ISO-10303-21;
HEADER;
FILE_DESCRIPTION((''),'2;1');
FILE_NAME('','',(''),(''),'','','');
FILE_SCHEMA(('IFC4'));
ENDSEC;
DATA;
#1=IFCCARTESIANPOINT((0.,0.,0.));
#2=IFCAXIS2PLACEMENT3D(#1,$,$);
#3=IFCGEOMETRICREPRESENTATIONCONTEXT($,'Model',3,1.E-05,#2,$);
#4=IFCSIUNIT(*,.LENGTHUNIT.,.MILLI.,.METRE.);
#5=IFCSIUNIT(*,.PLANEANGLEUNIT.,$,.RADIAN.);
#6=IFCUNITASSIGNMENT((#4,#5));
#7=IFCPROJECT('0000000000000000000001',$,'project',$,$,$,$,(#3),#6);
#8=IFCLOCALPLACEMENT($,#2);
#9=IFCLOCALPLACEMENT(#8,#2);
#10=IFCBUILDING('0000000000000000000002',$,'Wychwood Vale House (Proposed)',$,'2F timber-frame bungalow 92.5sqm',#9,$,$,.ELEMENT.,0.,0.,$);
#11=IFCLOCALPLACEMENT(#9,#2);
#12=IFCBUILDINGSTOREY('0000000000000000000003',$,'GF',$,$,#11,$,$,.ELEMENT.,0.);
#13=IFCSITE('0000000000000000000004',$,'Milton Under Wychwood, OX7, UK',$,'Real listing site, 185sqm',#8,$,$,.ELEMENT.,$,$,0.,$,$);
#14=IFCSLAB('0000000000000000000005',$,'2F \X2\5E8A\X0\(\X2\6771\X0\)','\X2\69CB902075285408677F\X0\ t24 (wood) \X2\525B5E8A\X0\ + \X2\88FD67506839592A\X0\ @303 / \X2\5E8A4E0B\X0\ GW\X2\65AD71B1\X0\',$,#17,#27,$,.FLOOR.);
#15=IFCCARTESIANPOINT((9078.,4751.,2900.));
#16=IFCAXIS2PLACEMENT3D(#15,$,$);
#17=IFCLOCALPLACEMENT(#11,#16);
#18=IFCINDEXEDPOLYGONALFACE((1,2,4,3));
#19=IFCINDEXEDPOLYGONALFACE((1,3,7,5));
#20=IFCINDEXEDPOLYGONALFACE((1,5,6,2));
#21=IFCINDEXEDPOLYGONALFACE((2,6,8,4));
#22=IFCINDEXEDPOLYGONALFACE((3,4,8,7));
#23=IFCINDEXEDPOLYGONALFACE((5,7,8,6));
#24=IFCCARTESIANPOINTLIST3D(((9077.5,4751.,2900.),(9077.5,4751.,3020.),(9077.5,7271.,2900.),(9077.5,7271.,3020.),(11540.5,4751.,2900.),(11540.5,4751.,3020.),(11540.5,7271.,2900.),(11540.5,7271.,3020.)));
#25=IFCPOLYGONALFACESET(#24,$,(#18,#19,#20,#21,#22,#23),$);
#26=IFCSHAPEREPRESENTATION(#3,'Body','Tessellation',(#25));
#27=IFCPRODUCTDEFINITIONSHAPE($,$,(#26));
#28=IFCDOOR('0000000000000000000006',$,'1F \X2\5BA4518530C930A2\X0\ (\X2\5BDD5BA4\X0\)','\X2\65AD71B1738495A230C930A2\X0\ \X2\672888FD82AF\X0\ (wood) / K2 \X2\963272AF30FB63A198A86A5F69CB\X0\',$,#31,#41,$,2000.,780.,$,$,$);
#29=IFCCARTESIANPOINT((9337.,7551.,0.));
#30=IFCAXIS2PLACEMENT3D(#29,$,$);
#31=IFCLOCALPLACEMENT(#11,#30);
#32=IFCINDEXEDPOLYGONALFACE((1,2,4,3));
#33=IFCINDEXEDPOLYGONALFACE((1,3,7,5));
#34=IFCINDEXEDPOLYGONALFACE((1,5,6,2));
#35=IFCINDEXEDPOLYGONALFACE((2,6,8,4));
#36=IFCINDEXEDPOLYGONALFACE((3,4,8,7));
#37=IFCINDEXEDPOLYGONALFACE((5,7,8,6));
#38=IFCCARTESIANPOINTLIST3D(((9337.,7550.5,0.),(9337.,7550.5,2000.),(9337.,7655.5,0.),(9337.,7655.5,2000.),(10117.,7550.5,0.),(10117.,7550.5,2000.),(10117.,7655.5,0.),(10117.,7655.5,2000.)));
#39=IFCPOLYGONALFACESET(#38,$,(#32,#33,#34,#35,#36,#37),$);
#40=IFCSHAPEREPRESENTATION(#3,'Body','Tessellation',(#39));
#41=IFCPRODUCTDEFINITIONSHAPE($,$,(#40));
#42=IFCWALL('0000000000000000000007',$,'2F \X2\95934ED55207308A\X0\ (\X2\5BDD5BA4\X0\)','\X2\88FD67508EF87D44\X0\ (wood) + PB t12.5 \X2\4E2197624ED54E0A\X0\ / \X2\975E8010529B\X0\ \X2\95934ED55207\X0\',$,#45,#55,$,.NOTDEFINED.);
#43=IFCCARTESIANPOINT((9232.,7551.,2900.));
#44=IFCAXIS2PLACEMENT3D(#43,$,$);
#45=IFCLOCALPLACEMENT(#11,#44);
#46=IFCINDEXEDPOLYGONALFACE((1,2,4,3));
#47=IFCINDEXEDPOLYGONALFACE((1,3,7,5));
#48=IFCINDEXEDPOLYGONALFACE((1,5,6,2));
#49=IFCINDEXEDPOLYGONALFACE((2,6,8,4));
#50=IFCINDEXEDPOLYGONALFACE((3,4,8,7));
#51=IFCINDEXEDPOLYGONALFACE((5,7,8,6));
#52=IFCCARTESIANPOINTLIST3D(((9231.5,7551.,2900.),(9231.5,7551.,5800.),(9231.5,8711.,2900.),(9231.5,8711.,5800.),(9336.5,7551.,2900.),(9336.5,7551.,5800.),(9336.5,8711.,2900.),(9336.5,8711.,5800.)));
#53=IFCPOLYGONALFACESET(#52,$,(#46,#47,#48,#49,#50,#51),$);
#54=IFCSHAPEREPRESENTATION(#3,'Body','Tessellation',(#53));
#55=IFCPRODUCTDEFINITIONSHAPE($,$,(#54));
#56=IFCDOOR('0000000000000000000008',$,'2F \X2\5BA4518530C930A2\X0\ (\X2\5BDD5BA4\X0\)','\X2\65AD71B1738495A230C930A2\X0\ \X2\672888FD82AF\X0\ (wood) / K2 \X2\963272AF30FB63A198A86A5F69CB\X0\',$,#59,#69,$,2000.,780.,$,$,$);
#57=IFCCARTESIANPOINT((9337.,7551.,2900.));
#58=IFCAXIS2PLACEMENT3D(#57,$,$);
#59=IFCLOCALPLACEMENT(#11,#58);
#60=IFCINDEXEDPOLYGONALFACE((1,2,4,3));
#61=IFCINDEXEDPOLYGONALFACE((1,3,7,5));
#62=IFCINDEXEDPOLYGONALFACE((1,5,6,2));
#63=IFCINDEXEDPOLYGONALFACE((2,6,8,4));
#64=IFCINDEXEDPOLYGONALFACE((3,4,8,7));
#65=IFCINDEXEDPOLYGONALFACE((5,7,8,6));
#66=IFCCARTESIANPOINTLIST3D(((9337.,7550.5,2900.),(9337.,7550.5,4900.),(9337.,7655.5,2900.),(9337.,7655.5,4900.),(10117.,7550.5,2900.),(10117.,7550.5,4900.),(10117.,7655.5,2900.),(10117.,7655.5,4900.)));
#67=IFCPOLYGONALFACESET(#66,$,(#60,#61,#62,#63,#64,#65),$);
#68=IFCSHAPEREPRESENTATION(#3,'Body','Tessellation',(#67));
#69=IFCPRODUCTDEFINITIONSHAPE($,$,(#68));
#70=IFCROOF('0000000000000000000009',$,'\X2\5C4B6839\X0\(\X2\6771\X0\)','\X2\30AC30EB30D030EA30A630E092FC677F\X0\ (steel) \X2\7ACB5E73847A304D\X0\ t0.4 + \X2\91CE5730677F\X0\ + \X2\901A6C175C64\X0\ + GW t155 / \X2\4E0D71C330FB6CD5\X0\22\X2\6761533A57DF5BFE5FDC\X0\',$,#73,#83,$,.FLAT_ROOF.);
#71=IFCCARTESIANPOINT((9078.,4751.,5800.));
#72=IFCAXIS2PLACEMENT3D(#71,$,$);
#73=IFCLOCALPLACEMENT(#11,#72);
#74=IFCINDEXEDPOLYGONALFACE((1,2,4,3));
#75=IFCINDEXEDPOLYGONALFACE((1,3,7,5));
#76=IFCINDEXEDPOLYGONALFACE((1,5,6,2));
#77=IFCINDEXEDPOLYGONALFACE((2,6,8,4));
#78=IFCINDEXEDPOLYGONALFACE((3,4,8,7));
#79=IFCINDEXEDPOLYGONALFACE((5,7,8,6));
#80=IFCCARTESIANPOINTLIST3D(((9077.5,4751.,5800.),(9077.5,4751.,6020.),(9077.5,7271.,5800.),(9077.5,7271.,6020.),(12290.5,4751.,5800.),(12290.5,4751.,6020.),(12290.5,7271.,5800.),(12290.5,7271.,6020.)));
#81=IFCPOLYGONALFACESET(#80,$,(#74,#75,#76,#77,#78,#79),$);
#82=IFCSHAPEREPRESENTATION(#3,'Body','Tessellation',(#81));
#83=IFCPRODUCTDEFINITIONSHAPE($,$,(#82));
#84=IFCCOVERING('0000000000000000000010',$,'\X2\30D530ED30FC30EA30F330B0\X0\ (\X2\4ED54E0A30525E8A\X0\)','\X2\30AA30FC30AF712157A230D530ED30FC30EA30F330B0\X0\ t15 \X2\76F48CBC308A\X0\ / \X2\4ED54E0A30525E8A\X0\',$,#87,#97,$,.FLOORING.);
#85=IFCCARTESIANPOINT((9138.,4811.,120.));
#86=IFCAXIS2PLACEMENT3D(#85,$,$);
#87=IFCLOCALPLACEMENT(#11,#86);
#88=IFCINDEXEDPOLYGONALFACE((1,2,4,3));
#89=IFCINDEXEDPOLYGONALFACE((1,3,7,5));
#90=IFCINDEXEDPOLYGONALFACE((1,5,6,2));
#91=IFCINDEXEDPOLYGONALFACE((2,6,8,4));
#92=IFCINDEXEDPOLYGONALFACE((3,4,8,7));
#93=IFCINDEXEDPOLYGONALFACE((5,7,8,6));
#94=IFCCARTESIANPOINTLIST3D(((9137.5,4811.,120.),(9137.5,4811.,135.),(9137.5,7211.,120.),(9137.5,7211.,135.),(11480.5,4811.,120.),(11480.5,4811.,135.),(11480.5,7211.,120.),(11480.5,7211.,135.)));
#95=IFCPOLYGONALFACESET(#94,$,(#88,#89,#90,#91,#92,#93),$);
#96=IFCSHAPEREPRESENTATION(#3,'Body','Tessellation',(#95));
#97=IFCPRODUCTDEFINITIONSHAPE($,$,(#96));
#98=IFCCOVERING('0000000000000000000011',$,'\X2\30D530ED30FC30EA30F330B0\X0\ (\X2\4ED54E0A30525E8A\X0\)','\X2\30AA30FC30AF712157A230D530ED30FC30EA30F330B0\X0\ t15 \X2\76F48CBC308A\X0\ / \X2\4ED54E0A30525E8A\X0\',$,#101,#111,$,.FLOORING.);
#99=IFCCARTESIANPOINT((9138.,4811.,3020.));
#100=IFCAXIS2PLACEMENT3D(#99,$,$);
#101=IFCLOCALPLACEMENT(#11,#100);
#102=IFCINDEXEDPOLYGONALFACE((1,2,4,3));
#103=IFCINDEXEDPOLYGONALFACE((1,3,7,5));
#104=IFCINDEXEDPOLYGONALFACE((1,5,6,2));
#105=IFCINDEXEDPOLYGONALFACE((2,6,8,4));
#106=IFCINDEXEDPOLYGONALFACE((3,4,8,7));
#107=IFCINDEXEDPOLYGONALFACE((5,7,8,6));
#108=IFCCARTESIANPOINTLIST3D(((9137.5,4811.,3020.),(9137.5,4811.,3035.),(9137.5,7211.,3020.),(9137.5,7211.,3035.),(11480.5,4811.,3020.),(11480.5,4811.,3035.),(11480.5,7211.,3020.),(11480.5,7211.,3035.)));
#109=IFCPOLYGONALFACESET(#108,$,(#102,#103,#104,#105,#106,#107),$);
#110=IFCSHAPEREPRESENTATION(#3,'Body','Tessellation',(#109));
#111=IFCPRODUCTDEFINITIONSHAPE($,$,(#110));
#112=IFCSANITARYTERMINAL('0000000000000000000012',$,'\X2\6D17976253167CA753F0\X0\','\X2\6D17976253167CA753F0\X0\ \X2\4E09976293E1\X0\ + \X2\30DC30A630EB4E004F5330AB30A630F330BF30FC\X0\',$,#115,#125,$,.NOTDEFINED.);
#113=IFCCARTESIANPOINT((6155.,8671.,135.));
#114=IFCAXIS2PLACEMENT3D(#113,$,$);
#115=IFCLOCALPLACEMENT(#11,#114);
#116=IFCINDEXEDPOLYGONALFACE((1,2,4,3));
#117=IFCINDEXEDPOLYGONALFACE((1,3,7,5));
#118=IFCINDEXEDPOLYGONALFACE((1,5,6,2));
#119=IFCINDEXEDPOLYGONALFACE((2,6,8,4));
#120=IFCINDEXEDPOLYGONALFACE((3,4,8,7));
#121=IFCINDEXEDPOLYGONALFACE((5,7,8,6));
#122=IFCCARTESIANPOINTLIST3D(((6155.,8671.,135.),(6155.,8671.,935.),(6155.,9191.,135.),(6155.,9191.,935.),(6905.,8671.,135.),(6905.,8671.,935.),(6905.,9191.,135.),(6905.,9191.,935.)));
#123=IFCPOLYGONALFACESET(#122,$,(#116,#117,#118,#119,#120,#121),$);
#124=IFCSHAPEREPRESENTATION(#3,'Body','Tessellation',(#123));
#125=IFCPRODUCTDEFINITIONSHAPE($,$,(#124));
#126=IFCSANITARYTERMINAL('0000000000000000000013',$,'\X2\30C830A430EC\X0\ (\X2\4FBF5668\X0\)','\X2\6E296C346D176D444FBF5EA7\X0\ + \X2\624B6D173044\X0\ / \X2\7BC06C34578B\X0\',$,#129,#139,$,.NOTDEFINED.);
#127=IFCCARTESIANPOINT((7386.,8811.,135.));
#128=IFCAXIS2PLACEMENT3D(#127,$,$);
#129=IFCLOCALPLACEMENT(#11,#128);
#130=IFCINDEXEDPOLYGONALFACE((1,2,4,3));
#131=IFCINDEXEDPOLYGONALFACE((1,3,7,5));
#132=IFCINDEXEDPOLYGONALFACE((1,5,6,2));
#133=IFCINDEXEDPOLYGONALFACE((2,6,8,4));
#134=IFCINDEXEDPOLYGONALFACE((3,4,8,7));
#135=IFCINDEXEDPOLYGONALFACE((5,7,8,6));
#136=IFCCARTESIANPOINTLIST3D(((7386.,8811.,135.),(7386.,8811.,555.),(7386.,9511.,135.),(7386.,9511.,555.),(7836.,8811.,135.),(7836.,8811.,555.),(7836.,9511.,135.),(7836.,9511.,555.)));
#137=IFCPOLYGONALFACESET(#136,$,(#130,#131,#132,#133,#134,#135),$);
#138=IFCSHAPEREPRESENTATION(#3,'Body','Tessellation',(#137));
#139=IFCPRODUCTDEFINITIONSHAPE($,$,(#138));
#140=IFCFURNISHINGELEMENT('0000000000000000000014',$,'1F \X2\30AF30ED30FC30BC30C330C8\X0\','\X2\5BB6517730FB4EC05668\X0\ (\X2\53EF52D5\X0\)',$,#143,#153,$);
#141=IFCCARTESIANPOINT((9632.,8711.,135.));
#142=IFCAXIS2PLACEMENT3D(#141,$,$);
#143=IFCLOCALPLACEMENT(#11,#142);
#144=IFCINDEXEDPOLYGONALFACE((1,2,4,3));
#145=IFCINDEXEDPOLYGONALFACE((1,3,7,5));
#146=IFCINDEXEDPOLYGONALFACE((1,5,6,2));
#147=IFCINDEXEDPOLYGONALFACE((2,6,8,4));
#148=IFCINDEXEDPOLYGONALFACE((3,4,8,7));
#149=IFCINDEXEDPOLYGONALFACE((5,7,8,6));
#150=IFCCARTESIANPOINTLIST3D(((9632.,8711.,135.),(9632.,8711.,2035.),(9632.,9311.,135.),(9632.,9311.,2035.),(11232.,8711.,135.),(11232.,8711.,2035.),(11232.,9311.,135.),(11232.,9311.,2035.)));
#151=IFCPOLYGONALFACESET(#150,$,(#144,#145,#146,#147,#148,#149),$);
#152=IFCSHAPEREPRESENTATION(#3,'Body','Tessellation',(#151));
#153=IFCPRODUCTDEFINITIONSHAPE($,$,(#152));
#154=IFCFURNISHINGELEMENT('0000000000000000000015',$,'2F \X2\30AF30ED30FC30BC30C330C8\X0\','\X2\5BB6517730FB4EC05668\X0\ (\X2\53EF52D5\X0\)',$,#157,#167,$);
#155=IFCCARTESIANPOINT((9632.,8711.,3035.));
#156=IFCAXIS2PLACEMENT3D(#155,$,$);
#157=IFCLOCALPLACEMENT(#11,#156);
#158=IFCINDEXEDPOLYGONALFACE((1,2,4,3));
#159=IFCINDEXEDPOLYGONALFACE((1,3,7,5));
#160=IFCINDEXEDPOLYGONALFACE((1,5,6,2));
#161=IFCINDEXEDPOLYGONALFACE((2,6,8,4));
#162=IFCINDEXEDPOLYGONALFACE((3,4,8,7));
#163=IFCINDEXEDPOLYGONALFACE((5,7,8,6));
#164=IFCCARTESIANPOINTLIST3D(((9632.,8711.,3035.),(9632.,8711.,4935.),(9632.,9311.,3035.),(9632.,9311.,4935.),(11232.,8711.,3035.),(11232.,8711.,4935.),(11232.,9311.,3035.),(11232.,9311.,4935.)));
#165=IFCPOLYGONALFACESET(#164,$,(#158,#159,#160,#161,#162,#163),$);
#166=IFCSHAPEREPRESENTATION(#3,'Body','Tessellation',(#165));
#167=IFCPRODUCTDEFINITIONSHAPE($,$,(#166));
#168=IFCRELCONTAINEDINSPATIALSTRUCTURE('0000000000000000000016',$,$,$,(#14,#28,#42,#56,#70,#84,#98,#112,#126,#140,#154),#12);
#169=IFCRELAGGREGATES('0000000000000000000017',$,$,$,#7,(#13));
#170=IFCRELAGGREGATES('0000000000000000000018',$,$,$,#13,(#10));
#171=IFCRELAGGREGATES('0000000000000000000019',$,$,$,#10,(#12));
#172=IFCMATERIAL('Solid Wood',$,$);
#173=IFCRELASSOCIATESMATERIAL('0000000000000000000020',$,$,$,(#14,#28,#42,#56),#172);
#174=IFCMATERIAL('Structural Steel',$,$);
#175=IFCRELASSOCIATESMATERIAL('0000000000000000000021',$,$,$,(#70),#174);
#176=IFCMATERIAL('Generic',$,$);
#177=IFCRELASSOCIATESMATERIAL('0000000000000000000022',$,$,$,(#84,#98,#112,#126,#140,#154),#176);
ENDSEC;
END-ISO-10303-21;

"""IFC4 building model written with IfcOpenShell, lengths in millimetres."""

from ifc_helpers import new_model, si_unit, frame, frame_2d, origin, place, context, project, spatial, rectangle, extrude, material, element, save


model = new_model("IFC4")

# Units and contexts
model_context = context("Model", 3, precision=1e-05, world=origin())
ifc_project = project(units=[si_unit("LENGTHUNIT", "METRE", prefix="MILLI"), si_unit("PLANEANGLEUNIT", "RADIAN")], contexts=[model_context])

# Site, building, storey
site_placement = place(None, origin())
site = spatial("IfcSite", under=ifc_project, at=site_placement, Name="Milton Under Wychwood, OX7, UK", ObjectType="Real listing site, 185sqm", CompositionType="ELEMENT", RefElevation=0.0)
building_placement = place(site_placement, origin())
building = spatial("IfcBuilding", under=site, at=building_placement, Name="Wychwood Vale House (Proposed)", ObjectType="2F timber-frame bungalow 92.5sqm", CompositionType="ELEMENT", ElevationOfRefHeight=0.0, ElevationOfTerrain=0.0)
storey_placement = place(building_placement, origin())
storey = spatial("IfcBuildingStorey", under=building, at=storey_placement, Name="GF", CompositionType="ELEMENT", Elevation=0.0)

# Slab
ifc_material_1 = material(Name="Solid Wood")
slab_1_placement = place(storey_placement, frame((9078.0, 4751.0, 2900.0)))
element("IfcSlab", 1, at=slab_1_placement, inside=storey, material=ifc_material_1, Name="2F 床(東)", Description="構造用合板 t24 (wood) 剛床 + 製材根太 @303 / 床下 GW断熱", PredefinedType="FLOOR", context=model_context, shape_type="SweptSolid", body=[
    extrude(rectangle(XDim=2463.0, YDim=2520.0, at=frame_2d((1231.0, 1260.0))), frame((9078.0, 4751.0, 2900.0)), (0.0, 0.0, 1.0), 120.0),
])

# Door
door_1_placement = place(storey_placement, frame((9337.0, 7551.0, 0.0)))
element("IfcDoor", 2, at=door_1_placement, inside=storey, material=ifc_material_1, Name="1F 室内ドア (寝室)", Description="断熱玄関ドア 木製芯 (wood) / K2 防犯・採風機構", OverallHeight=2000.0, OverallWidth=780.0, context=model_context, shape_type="SweptSolid", body=[
    extrude(rectangle(XDim=780.0, YDim=105.0, at=frame_2d((390.0, 52.0))), frame((9337.0, 7551.0, 0.0)), (0.0, 0.0, 1.0), 2000.0),
])

# Wall
wall_1_placement = place(storey_placement, frame((9232.0, 7551.0, 2900.0)))
element("IfcWall", 3, at=wall_1_placement, inside=storey, material=ifc_material_1, Name="2F 間仕切り (寝室)", Description="製材軸組 (wood) + PB t12.5 両面仕上 / 非耐力 間仕切", PredefinedType="NOTDEFINED", context=model_context, shape_type="SweptSolid", body=[
    extrude(rectangle(XDim=105.0, YDim=1160.0, at=frame_2d((52.0, 580.0))), frame((9232.0, 7551.0, 2900.0)), (0.0, 0.0, 1.0), 2900.0),
])

# Door
door_2_placement = place(storey_placement, frame((9337.0, 7551.0, 2900.0)))
element("IfcDoor", 4, at=door_2_placement, inside=storey, material=ifc_material_1, Name="2F 室内ドア (寝室)", Description="断熱玄関ドア 木製芯 (wood) / K2 防犯・採風機構", OverallHeight=2000.0, OverallWidth=780.0, context=model_context, shape_type="SweptSolid", body=[
    extrude(rectangle(XDim=780.0, YDim=105.0, at=frame_2d((390.0, 52.0))), frame((9337.0, 7551.0, 2900.0)), (0.0, 0.0, 1.0), 2000.0),
])

# Roof
ifc_material_2 = material(Name="Structural Steel")
for number, where, name in (
    (5, (9078.0, 4751.0, 5800.0), "屋根(東)"),
):
    element("IfcRoof", number, at=place(storey_placement, frame(where)), inside=storey, material=ifc_material_2, Name=name, Description="ガルバリウム鋼板 (steel) 立平葺き t0.4 + 野地板 + 通気層 + GW t155 / 不燃・法22条区域対応", PredefinedType="FLAT_ROOF", context=model_context, shape_type="SweptSolid", body=[
        extrude(rectangle(XDim=3213.0, YDim=2520.0, at=frame_2d((1606.0, 1260.0))), frame((9078.0, 4751.0, 5800.0)), (0.0, 0.0, 1.0), 220.0),
    ])

# Coverings
ifc_material_3 = material(Name="Generic")
covering_1_placement = place(storey_placement, frame((9138.0, 4811.0, 120.0)))
element("IfcCovering", 6, at=covering_1_placement, inside=storey, material=ifc_material_3, Name="フローリング (仕上げ床)", Description="オーク無垢フローリング t15 直貼り / 仕上げ床", PredefinedType="FLOORING", context=model_context, shape_type="SweptSolid", body=[
    extrude(rectangle(XDim=2343.0, YDim=2400.0, at=frame_2d((1171.0, 1200.0))), frame((9138.0, 4811.0, 120.0)), (0.0, 0.0, 1.0), 15.0),
])
covering_2_placement = place(storey_placement, frame((9138.0, 4811.0, 3020.0)))
element("IfcCovering", 7, at=covering_2_placement, inside=storey, material=ifc_material_3, Name="フローリング (仕上げ床)", Description="オーク無垢フローリング t15 直貼り / 仕上げ床", PredefinedType="FLOORING", context=model_context, shape_type="SweptSolid", body=[
    extrude(rectangle(XDim=2343.0, YDim=2400.0, at=frame_2d((1171.0, 1200.0))), frame((9138.0, 4811.0, 3020.0)), (0.0, 0.0, 1.0), 15.0),
])

# Sanitary terminals
sanitary_terminal_1_placement = place(storey_placement, frame((6155.0, 8671.0, 135.0)))
element("IfcSanitaryTerminal", 8, at=sanitary_terminal_1_placement, inside=storey, material=ifc_material_3, Name="洗面化粧台", Description="洗面化粧台 三面鏡 + ボウル一体カウンター", PredefinedType="NOTDEFINED", context=model_context, shape_type="SweptSolid", body=[
    extrude(rectangle(XDim=750.0, YDim=520.0, at=frame_2d((375.0, 260.0))), frame((6155.0, 8671.0, 135.0)), (0.0, 0.0, 1.0), 800.0),
])
sanitary_terminal_2_placement = place(storey_placement, frame((7386.0, 8811.0, 135.0)))
element("IfcSanitaryTerminal", 9, at=sanitary_terminal_2_placement, inside=storey, material=ifc_material_3, Name="トイレ (便器)", Description="温水洗浄便座 + 手洗い / 節水型", PredefinedType="NOTDEFINED", context=model_context, shape_type="SweptSolid", body=[
    extrude(rectangle(XDim=450.0, YDim=700.0, at=frame_2d((225.0, 350.0))), frame((7386.0, 8811.0, 135.0)), (0.0, 0.0, 1.0), 420.0),
])

# Furnishing elements
furnishing_1_placement = place(storey_placement, frame((9632.0, 8711.0, 135.0)))
element("IfcFurnishingElement", 10, at=furnishing_1_placement, inside=storey, material=ifc_material_3, Name="1F クローゼット", Description="家具・什器 (可動)", context=model_context, shape_type="SweptSolid", body=[
    extrude(rectangle(XDim=1600.0, YDim=600.0, at=frame_2d((800.0, 300.0))), frame((9632.0, 8711.0, 135.0)), (0.0, 0.0, 1.0), 1900.0),
])
furnishing_2_placement = place(storey_placement, frame((9632.0, 8711.0, 3035.0)))
element("IfcFurnishingElement", 11, at=furnishing_2_placement, inside=storey, material=ifc_material_3, Name="2F クローゼット", Description="家具・什器 (可動)", context=model_context, shape_type="SweptSolid", body=[
    extrude(rectangle(XDim=1600.0, YDim=600.0, at=frame_2d((800.0, 300.0))), frame((9632.0, 8711.0, 3035.0)), (0.0, 0.0, 1.0), 1900.0),
])

save(model, "model.ifc")
